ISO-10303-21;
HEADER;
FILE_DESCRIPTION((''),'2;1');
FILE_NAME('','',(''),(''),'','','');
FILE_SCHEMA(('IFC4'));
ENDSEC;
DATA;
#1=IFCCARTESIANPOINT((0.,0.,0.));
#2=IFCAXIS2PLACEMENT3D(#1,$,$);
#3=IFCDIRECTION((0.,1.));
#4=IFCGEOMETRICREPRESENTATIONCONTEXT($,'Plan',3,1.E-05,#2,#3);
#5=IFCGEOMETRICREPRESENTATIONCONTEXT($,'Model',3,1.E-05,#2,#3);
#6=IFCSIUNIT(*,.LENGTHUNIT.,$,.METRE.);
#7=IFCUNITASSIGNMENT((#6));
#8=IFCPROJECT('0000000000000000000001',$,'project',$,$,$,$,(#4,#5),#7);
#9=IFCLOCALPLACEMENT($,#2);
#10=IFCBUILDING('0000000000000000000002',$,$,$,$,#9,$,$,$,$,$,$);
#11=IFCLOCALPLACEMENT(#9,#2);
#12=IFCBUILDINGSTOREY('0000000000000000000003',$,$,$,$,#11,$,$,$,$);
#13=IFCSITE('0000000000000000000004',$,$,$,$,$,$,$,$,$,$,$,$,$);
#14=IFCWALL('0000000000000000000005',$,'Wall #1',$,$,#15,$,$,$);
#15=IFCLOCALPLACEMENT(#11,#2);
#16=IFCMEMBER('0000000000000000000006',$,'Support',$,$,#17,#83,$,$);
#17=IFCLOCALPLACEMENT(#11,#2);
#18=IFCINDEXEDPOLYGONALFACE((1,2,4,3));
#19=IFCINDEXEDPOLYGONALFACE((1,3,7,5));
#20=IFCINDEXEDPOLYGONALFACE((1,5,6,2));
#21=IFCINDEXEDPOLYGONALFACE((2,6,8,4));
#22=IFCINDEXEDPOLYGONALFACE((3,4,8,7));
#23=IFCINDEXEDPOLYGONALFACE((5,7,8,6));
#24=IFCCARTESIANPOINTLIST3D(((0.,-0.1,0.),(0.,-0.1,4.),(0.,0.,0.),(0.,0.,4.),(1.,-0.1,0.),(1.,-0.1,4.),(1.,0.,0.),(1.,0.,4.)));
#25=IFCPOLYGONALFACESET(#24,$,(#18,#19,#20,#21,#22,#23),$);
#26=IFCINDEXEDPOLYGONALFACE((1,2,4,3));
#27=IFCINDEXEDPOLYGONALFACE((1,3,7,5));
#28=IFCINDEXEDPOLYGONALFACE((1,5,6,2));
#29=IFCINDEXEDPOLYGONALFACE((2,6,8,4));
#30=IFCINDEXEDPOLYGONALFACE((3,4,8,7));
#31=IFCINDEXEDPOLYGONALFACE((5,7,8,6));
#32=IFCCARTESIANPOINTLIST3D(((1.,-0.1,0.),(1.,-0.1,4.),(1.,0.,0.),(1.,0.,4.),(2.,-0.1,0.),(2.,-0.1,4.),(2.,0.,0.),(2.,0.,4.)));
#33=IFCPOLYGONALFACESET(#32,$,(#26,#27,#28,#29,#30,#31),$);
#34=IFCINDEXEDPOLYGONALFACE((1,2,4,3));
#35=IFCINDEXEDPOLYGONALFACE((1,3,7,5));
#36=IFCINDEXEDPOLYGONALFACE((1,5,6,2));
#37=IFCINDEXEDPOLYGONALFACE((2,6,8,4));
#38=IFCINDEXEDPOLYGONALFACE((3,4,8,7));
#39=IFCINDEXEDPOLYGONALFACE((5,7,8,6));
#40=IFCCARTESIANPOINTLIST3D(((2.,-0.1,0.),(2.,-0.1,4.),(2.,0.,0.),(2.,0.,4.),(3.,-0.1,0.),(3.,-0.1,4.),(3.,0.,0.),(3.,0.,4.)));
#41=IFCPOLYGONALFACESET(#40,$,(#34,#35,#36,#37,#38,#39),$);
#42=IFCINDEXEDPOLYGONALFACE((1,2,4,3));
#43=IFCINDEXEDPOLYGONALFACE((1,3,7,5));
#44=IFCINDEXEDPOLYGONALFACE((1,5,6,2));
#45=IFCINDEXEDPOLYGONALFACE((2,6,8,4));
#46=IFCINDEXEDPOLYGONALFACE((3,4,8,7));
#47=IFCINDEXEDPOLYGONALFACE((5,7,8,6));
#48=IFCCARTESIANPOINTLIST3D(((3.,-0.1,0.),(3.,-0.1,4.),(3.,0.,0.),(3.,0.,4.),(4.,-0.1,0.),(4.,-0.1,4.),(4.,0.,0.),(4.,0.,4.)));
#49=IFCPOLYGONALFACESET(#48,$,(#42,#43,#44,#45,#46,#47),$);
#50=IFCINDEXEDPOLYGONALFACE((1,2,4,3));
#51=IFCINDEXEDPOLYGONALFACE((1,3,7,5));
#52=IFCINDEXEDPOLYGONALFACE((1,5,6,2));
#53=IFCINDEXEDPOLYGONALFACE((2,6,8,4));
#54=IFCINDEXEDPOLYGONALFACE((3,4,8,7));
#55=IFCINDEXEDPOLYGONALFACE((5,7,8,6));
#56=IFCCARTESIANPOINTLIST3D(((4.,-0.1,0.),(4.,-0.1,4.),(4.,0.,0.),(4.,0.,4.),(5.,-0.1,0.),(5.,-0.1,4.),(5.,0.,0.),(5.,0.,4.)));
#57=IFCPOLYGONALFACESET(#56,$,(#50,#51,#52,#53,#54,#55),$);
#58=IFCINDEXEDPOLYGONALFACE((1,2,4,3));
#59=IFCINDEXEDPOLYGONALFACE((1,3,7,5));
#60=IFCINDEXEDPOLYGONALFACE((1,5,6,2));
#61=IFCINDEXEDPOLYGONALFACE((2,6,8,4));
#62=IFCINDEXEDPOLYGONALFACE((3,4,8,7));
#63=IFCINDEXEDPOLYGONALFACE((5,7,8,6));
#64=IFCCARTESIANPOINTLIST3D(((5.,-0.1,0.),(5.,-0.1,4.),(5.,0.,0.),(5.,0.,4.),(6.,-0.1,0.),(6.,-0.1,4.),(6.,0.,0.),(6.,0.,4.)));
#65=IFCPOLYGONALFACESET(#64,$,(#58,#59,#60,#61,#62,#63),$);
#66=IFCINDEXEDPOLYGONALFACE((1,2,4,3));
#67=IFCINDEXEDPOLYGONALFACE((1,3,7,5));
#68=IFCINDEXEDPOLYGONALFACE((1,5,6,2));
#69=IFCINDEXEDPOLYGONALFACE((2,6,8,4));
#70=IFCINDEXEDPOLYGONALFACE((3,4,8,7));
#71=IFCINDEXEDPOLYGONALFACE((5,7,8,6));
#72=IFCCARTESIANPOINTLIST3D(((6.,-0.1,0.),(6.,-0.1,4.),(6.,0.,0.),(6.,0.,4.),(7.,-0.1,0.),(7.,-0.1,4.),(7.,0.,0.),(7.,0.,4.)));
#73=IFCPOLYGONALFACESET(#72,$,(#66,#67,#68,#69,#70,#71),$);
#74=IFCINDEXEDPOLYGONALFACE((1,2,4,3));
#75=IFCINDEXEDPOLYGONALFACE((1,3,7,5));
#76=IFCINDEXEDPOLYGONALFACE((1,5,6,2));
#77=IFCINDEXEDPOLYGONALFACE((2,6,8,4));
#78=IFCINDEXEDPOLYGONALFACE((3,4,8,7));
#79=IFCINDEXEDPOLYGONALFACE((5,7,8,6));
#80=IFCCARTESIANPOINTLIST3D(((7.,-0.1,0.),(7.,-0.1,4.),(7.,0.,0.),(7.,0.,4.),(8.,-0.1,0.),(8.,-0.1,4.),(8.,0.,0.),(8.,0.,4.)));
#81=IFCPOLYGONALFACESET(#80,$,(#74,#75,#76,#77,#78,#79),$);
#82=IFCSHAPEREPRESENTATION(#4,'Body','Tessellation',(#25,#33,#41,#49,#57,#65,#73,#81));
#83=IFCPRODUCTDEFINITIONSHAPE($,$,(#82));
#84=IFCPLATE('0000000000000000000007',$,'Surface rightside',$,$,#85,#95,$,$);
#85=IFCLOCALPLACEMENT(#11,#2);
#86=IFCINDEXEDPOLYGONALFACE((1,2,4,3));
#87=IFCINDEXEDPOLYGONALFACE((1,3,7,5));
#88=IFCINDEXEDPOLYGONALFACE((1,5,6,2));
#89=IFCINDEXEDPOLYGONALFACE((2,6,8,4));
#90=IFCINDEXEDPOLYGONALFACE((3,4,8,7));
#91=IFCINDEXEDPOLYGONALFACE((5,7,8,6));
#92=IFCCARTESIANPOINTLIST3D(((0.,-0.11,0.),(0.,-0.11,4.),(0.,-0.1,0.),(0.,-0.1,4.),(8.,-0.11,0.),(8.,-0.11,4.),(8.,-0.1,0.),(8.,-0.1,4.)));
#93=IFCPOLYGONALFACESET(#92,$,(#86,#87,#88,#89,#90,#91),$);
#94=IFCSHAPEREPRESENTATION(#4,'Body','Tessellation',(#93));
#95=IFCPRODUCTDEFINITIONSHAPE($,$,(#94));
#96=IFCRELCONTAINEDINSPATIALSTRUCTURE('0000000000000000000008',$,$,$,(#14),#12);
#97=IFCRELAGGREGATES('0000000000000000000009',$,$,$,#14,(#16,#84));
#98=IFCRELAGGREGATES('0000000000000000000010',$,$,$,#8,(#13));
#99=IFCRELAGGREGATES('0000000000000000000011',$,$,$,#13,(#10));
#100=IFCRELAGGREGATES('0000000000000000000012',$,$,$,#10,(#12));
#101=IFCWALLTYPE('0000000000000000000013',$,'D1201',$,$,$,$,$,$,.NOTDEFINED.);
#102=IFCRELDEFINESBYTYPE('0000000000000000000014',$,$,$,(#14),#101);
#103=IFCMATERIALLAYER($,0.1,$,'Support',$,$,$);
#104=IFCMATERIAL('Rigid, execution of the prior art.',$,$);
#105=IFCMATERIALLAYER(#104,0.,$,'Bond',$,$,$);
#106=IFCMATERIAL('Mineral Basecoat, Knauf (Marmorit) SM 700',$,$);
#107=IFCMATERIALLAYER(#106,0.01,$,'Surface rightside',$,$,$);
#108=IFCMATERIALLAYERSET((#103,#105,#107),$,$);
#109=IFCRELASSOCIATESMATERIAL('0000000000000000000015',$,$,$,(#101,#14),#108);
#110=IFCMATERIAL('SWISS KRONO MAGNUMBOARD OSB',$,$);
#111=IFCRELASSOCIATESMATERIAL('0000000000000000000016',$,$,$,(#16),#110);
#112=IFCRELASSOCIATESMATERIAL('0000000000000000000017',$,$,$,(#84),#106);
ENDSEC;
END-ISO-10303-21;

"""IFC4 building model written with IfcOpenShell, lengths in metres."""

from ifc_helpers import new_model, si_unit, direction, frame, frame_2d, origin, place, context, project, spatial, rectangle, extrude, material, layer, layer_set, type_object, element, aggregate, save


model = new_model("IFC4")

# Units and contexts
plan_context = context("Plan", 3, precision=1e-05, world=origin(), true_north=direction((0.0, 1.0)))
model_context = context("Model", 3, precision=1e-05, world=origin(), true_north=direction((0.0, 1.0)))
ifc_project = project(units=[si_unit("LENGTHUNIT", "METRE")], contexts=[plan_context, model_context])

# Site, building, storey
site = spatial("IfcSite", under=ifc_project)
building_placement = place(None, origin())
building = spatial("IfcBuilding", under=site, at=building_placement)
storey_placement = place(building_placement, origin())
storey = spatial("IfcBuildingStorey", under=building, at=storey_placement)

# Wall, member, plate
ifc_layer_1 = layer(None, 0.1, Name="Support")
ifc_material_1 = material(Name="Rigid, execution of the prior art.")
ifc_layer_2 = layer(ifc_material_1, 0.0, Name="Bond")
ifc_material_2 = material(Name="Mineral Basecoat, Knauf (Marmorit) SM 700")
ifc_layer_3 = layer(ifc_material_2, 0.01, Name="Surface rightside")
ifc_layer_set = layer_set([ifc_layer_1, ifc_layer_2, ifc_layer_3])
wall_type = type_object("IfcWallType", Name="D1201", PredefinedType="NOTDEFINED", material=ifc_layer_set)
wall_placement = place(None, frame((0.0, 0.0, 0.0), z_axis=(0.0, -1.0, 0.0), x_axis=(1.0, 0.0, 0.0)))
wall = element("IfcWall", 1, at=wall_placement, inside=storey, type_object=wall_type, material=ifc_layer_set, Name="Wall #1")
ifc_material_3 = material(Name="SWISS KRONO MAGNUMBOARD OSB")
member_placement = place(wall_placement, origin())
member = element("IfcMember", 2, at=member_placement, material=ifc_material_3, Name="Support", context=plan_context, shape_type="SweptSolid", body=[
    extrude(rectangle(XDim=1.0, YDim=0.1, at=frame_2d((0.5, 0.05), x_axis=(1.0, 0.0))), frame((0.0, 4.0, 0.0), z_axis=(0.0, -1.0, 0.0), x_axis=(1.0, 0.0, 0.0)), (0.0, 0.0, 1.0), 4.0),
    extrude(rectangle(XDim=1.0, YDim=0.1, at=frame_2d((0.5, 0.05), x_axis=(1.0, 0.0))), frame((1.0, 4.0, 0.0), z_axis=(0.0, -1.0, 0.0), x_axis=(1.0, 0.0, 0.0)), (0.0, 0.0, 1.0), 4.0),
    extrude(rectangle(XDim=1.0, YDim=0.1, at=frame_2d((0.5, 0.05), x_axis=(1.0, 0.0))), frame((2.0, 4.0, 0.0), z_axis=(0.0, -1.0, 0.0), x_axis=(1.0, 0.0, 0.0)), (0.0, 0.0, 1.0), 4.0),
    extrude(rectangle(XDim=1.0, YDim=0.1, at=frame_2d((0.5, 0.05), x_axis=(1.0, 0.0))), frame((3.0, 4.0, 0.0), z_axis=(0.0, -1.0, 0.0), x_axis=(1.0, 0.0, 0.0)), (0.0, 0.0, 1.0), 4.0),
    extrude(rectangle(XDim=1.0, YDim=0.1, at=frame_2d((0.5, 0.05), x_axis=(1.0, 0.0))), frame((4.0, 4.0, 0.0), z_axis=(0.0, -1.0, 0.0), x_axis=(1.0, 0.0, 0.0)), (0.0, 0.0, 1.0), 4.0),
    extrude(rectangle(XDim=1.0, YDim=0.1, at=frame_2d((0.5, 0.05), x_axis=(1.0, 0.0))), frame((5.0, 4.0, 0.0), z_axis=(0.0, -1.0, 0.0), x_axis=(1.0, 0.0, 0.0)), (0.0, 0.0, 1.0), 4.0),
    extrude(rectangle(XDim=1.0, YDim=0.1, at=frame_2d((0.5, 0.05), x_axis=(1.0, 0.0))), frame((6.0, 4.0, 0.0), z_axis=(0.0, -1.0, 0.0), x_axis=(1.0, 0.0, 0.0)), (0.0, 0.0, 1.0), 4.0),
    extrude(rectangle(XDim=1.0, YDim=0.1, at=frame_2d((0.5, 0.05), x_axis=(1.0, 0.0))), frame((7.0, 4.0, 0.0), z_axis=(0.0, -1.0, 0.0), x_axis=(1.0, 0.0, 0.0)), (0.0, 0.0, 1.0), 4.0),
])
plate_placement = place(wall_placement, origin())
plate = element("IfcPlate", 3, at=plate_placement, material=ifc_material_2, Name="Surface rightside", context=plan_context, shape_type="SweptSolid", body=[
    extrude(rectangle(XDim=8.0, YDim=4.0, at=frame_2d((4.0, 2.0), x_axis=(1.0, 0.0))), frame((0.0, 0.0, 0.1), z_axis=(0.0, 0.0, 1.0), x_axis=(1.0, 0.0, 0.0)), (0.0, 0.0, 1.0), 0.01),
])
aggregate(wall, [member, plate])

save(model, "model.ifc")
